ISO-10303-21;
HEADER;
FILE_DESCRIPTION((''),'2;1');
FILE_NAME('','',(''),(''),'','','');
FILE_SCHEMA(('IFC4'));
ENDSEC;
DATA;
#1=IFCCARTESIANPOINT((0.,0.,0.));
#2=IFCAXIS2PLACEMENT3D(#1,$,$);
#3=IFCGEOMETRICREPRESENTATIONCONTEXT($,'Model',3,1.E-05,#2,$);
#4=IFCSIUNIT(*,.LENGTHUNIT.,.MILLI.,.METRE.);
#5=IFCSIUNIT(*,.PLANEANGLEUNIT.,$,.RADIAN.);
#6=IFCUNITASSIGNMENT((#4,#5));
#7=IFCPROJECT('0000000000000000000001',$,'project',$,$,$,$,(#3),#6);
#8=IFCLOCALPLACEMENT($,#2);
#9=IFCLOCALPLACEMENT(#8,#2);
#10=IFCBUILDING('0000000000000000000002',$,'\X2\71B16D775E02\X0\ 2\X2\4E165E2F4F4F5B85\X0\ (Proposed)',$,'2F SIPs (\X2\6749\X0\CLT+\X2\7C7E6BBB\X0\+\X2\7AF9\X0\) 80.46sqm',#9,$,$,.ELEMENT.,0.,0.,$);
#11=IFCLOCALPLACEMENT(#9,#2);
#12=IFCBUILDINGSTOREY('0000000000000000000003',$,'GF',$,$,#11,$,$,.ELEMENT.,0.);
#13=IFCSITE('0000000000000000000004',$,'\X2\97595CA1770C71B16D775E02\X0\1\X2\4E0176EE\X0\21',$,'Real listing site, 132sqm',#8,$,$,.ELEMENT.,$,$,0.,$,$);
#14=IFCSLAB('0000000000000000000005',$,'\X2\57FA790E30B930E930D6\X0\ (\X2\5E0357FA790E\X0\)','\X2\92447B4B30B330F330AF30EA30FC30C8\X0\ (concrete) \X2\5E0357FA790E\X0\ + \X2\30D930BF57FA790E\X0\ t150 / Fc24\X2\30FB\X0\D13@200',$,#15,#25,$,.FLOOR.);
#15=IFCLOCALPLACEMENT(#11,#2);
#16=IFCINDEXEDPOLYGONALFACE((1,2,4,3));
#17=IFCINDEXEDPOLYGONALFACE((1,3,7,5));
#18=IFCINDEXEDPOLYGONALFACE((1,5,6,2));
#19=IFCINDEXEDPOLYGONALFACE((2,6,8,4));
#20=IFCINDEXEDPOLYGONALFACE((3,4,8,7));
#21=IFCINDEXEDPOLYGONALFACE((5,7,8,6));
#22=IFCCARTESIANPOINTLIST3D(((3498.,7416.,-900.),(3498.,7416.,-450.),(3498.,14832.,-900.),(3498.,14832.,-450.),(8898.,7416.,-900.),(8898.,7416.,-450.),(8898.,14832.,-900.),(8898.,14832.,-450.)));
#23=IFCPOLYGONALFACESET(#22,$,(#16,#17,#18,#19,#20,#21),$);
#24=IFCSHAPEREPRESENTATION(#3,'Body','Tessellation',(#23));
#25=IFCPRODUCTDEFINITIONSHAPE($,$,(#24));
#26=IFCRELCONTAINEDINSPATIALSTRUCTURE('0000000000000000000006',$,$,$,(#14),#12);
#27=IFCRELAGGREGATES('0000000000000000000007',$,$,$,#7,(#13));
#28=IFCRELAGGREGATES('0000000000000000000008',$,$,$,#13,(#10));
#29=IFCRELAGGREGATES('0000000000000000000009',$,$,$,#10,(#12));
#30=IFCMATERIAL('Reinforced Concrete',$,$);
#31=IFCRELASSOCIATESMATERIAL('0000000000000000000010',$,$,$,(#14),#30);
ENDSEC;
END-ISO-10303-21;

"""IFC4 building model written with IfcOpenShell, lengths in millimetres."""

from ifc_helpers import new_model, si_unit, frame, frame_2d, origin, place, context, project, spatial, rectangle, extrude, material, element, save


model = new_model("IFC4")

# Units and contexts
model_context = context("Model", 3, precision=1e-05, world=origin())
ifc_project = project(units=[si_unit("LENGTHUNIT", "METRE", prefix="MILLI"), si_unit("PLANEANGLEUNIT", "RADIAN")], contexts=[model_context])

# Site, building, storey
site_placement = place(None, origin())
site = spatial("IfcSite", under=ifc_project, at=site_placement, Name="静岡県熱海市1丁目21", ObjectType="Real listing site, 132sqm", CompositionType="ELEMENT", RefElevation=0.0)
building_placement = place(site_placement, origin())
building = spatial("IfcBuilding", under=site, at=building_placement, Name="熱海市 2世帯住宅 (Proposed)", ObjectType="2F SIPs (杉CLT+籾殻+竹) 80.46sqm", CompositionType="ELEMENT", ElevationOfRefHeight=0.0, ElevationOfTerrain=0.0)
storey_placement = place(building_placement, origin())
storey = spatial("IfcBuildingStorey", under=building, at=storey_placement, Name="GF", CompositionType="ELEMENT", Elevation=0.0)

# Slab
ifc_material_1 = material(Name="Reinforced Concrete")
slab_1_placement = place(storey_placement, frame((1749.0, 3708.0, -450.0)))
element("IfcSlab", 1, at=slab_1_placement, inside=storey, material=ifc_material_1, Name="基礎スラブ (布基礎)", Description="鉄筋コンクリート (concrete) 布基礎 + ベタ基礎 t150 / Fc24・D13@200", PredefinedType="FLOOR", context=model_context, shape_type="SweptSolid", body=[
    extrude(rectangle(XDim=5400.0, YDim=7416.0, at=frame_2d((2700.0, 3708.0))), frame((1749.0, 3708.0, -450.0)), (0.0, 0.0, 1.0), 450.0),
])

save(model, "model.ifc")
